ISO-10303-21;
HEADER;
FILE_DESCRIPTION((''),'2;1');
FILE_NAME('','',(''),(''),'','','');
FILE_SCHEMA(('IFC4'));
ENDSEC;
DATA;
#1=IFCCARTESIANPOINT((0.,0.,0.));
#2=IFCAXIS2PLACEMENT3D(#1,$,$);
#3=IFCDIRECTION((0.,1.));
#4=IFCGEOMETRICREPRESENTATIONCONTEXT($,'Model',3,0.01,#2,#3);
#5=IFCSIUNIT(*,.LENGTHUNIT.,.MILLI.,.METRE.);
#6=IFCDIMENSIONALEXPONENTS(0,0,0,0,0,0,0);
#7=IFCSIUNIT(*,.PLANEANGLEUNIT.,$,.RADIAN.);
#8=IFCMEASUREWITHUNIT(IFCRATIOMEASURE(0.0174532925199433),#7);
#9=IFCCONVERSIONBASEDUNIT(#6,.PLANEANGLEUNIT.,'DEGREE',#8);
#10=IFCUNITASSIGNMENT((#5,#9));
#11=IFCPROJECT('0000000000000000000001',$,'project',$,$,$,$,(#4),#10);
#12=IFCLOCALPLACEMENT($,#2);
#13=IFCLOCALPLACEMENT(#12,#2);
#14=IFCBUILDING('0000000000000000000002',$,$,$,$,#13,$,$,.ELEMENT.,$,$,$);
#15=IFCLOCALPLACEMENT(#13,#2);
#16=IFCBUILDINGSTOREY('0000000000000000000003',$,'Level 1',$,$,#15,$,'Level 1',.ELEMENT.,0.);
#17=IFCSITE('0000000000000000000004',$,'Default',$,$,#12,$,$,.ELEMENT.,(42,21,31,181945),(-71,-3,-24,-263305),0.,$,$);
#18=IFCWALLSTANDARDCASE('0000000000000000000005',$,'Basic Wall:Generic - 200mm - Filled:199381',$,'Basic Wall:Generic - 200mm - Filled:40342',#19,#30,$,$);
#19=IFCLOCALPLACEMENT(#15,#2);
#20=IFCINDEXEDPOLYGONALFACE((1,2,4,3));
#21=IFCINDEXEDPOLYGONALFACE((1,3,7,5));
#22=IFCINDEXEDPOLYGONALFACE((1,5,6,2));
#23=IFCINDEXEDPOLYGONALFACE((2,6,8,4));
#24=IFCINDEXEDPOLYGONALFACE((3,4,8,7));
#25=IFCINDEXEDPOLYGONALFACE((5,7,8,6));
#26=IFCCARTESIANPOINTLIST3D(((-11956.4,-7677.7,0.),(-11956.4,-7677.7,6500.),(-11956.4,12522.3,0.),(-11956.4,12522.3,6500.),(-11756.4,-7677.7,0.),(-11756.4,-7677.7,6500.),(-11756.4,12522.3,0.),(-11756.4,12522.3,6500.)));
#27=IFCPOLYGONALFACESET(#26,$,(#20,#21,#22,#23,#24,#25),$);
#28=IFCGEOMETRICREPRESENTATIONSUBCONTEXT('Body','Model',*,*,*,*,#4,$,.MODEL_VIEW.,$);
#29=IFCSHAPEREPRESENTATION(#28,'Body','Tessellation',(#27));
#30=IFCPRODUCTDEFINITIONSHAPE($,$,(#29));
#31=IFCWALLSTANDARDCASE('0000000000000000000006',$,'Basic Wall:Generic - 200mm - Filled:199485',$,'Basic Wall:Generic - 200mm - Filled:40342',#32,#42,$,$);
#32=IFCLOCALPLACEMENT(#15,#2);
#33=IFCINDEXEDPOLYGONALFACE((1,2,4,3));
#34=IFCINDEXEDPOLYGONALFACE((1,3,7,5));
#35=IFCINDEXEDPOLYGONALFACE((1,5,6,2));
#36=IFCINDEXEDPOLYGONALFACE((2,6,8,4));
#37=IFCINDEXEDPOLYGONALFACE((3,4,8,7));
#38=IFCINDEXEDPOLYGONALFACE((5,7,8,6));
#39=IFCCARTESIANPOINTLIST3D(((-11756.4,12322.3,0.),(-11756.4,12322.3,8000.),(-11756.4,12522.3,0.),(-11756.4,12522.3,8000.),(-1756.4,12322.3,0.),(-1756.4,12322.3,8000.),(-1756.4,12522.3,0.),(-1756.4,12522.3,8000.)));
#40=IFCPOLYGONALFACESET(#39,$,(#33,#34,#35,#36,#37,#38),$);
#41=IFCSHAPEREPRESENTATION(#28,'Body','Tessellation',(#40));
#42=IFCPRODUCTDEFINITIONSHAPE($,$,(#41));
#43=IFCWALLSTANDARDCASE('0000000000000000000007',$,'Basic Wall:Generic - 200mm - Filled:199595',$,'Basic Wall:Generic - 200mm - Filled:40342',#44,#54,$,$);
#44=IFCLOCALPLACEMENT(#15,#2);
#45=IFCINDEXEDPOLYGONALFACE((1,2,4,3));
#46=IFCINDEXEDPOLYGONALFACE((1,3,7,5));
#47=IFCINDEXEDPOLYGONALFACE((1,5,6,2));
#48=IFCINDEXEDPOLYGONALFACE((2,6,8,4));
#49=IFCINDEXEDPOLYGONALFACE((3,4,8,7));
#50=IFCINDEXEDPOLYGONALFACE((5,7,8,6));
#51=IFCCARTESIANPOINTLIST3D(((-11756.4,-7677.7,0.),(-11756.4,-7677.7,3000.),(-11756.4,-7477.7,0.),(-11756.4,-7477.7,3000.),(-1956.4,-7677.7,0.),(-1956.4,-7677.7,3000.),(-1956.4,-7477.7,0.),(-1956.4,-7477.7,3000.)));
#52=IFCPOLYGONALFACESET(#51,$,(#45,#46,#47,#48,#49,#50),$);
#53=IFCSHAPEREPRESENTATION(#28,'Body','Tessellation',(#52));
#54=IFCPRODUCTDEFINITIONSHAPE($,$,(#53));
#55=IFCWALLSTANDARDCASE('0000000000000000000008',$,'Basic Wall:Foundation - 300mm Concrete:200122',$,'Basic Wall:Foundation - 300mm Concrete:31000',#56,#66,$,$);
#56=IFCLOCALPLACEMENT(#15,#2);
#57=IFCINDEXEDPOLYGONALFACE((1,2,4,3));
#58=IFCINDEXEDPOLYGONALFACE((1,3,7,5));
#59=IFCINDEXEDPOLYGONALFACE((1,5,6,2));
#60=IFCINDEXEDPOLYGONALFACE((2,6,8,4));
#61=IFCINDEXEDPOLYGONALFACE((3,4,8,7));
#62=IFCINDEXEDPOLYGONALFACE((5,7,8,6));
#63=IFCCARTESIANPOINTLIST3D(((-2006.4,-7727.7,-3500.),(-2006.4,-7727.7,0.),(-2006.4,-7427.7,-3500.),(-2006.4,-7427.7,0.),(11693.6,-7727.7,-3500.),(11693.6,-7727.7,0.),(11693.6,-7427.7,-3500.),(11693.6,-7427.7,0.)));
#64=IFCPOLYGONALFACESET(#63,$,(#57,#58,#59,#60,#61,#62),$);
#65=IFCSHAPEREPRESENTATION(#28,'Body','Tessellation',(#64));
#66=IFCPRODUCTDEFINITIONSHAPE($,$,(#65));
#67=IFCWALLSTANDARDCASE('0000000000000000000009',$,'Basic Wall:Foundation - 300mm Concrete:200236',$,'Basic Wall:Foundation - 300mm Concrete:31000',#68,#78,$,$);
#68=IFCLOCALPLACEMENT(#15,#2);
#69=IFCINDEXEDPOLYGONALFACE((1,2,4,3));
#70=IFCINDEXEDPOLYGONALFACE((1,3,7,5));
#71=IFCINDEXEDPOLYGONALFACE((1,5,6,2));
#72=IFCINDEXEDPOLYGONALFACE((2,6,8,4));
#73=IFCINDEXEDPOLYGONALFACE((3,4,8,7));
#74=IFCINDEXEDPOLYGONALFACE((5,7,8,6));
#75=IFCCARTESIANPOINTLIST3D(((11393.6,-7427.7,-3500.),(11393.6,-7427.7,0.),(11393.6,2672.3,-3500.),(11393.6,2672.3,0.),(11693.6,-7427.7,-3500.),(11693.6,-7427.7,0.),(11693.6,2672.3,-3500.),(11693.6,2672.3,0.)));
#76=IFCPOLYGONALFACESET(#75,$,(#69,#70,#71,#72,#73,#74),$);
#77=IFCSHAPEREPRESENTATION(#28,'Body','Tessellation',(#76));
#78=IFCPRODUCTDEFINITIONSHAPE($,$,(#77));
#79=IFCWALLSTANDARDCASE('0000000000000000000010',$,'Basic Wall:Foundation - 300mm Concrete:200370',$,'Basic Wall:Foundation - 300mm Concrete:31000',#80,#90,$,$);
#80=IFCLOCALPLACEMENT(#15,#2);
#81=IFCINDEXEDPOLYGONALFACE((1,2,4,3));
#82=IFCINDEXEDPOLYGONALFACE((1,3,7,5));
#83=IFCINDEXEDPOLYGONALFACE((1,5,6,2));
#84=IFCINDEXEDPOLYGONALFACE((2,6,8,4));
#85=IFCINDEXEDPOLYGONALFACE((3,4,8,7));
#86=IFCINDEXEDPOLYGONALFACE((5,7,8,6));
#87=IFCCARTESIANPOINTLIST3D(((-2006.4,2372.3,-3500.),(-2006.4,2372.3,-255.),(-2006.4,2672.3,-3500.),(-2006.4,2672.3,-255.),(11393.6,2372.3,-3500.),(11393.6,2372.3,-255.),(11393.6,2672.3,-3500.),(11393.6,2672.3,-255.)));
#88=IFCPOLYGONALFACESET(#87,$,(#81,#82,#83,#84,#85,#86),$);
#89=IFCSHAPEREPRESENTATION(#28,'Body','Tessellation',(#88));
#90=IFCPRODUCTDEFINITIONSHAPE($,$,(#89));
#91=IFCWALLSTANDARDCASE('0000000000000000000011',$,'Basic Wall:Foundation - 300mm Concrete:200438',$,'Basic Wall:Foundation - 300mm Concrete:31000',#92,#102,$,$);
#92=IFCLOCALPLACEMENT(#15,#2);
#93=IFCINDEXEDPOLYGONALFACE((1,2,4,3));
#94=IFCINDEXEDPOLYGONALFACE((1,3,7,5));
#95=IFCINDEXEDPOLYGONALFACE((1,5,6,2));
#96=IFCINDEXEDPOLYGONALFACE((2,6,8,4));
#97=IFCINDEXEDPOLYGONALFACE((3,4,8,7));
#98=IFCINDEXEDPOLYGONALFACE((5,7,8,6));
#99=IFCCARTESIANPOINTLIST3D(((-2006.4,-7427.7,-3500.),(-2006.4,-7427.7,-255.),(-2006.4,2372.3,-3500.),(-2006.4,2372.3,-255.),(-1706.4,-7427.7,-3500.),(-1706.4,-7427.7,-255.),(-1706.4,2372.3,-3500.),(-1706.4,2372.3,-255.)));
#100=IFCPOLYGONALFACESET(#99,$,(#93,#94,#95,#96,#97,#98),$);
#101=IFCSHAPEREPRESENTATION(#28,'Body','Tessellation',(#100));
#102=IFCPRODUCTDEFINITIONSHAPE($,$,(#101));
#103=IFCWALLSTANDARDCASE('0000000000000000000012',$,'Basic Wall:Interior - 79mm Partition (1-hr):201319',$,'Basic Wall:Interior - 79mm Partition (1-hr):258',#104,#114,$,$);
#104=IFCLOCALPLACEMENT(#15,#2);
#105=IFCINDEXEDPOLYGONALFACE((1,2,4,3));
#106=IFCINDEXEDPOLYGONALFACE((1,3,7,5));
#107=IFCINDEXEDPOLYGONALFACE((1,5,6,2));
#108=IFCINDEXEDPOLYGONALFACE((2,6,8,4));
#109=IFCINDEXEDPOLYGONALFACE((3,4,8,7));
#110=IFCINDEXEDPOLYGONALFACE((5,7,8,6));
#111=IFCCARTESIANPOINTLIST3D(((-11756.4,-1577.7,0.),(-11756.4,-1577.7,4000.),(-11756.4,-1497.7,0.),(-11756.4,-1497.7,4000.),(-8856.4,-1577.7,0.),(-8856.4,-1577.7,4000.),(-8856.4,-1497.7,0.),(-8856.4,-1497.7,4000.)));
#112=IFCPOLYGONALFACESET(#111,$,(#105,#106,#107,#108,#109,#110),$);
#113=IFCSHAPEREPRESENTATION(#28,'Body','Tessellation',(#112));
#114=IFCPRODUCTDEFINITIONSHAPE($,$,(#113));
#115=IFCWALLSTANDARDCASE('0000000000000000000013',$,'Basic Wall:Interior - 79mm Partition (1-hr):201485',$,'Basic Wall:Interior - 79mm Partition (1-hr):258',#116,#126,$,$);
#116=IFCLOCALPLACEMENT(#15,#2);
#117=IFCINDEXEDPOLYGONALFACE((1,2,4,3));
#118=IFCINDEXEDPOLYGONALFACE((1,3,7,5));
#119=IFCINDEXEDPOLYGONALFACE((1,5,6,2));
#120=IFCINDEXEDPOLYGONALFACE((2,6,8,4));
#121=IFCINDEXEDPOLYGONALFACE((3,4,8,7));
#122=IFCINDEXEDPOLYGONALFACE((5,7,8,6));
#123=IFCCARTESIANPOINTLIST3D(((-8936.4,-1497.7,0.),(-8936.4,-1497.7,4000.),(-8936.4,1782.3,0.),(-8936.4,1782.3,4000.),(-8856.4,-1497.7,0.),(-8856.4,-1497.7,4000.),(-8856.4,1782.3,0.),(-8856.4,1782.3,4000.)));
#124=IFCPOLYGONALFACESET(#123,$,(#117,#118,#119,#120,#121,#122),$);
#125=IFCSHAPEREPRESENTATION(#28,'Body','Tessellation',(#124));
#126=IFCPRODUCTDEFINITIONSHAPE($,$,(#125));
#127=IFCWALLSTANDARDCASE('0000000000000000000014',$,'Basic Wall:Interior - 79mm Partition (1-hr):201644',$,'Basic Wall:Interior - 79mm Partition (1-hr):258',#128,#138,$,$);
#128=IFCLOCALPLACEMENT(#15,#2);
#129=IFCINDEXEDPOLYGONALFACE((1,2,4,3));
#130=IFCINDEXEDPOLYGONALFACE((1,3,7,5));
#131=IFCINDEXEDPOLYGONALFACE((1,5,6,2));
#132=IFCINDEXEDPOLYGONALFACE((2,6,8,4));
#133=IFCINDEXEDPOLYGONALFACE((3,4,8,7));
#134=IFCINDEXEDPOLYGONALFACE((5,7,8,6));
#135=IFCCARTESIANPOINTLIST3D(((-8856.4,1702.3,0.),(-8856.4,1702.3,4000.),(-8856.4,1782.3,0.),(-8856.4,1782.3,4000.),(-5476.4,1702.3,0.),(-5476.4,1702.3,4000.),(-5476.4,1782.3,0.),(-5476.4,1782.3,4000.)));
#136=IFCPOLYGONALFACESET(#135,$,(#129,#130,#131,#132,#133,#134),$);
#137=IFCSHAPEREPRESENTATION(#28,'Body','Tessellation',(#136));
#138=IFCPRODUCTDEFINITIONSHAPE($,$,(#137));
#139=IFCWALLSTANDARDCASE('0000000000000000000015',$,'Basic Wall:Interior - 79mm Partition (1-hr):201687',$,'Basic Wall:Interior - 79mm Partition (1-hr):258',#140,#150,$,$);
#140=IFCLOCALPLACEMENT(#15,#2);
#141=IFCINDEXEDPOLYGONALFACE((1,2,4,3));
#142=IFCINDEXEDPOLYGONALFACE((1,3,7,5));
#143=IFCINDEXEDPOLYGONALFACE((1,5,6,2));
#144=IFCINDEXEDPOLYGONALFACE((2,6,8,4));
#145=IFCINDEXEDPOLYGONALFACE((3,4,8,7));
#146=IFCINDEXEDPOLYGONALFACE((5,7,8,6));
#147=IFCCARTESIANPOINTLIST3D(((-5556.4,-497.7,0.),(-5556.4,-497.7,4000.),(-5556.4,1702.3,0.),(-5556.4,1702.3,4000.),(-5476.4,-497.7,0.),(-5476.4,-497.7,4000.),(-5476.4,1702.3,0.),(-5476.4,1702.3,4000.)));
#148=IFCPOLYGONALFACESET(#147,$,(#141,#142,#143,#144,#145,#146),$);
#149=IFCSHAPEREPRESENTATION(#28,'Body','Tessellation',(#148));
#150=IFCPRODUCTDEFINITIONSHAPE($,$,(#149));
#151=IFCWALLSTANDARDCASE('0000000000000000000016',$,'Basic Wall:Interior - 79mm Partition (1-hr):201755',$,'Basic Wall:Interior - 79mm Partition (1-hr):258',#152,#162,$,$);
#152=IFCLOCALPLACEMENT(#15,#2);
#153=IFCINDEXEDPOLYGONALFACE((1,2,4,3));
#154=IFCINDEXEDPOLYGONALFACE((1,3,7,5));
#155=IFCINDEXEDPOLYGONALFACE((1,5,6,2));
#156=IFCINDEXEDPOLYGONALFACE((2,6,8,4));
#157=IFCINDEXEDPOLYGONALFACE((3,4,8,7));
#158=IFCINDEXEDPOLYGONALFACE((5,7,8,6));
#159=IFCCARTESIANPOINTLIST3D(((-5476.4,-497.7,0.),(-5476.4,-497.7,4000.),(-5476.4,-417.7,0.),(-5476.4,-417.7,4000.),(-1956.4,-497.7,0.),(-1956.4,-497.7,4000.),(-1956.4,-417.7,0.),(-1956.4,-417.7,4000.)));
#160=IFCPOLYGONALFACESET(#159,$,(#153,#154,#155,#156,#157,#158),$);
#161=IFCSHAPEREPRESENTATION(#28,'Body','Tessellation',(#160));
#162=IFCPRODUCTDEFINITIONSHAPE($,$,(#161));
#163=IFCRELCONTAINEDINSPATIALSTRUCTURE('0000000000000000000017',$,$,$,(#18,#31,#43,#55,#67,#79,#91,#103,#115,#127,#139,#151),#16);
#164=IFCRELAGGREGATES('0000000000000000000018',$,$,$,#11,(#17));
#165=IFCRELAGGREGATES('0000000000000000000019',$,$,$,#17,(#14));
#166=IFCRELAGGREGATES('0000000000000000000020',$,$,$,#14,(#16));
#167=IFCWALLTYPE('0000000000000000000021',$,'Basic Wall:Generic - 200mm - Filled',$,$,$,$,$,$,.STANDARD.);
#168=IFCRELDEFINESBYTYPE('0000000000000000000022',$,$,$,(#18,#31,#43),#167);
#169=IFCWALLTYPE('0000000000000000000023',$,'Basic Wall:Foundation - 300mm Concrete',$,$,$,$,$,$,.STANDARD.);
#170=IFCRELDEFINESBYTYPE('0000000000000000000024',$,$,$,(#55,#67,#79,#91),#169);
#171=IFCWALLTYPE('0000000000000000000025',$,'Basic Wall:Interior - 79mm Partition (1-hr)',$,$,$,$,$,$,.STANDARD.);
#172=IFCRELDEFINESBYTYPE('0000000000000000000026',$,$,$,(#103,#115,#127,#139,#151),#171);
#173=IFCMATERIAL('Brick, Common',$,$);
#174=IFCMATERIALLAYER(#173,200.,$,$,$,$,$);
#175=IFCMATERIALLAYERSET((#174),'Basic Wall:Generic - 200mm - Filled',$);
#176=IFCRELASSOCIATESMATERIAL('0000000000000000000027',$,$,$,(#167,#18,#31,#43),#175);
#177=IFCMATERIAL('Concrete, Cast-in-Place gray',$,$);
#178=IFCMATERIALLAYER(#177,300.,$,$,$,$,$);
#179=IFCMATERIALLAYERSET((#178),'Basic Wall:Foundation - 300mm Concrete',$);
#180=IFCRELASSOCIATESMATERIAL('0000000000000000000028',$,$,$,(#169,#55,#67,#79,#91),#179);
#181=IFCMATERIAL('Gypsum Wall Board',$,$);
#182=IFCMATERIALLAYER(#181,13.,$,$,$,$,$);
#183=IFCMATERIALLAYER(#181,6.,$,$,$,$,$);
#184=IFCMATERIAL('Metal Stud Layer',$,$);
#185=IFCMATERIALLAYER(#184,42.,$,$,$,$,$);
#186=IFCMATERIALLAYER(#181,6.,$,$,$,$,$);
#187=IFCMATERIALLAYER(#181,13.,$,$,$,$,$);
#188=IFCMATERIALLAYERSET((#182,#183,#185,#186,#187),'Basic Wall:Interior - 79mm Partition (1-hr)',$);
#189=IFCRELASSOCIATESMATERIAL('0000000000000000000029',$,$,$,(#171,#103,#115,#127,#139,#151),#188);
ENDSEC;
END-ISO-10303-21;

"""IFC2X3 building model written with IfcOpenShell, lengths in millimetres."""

from ifc_helpers import new_model, entity, si_unit, converted_unit, direction, frame, frame_2d, origin, place, context, subcontext, project, spatial, polyline, rectangle, extrude, clip, bounded_halfspace, material, layer, layer_set, layer_usage, type_object, element, save


model = new_model("IFC2X3")

# Units and contexts
model_context = context("Model", 3, precision=0.01, world=origin(), true_north=direction((0.0, 1.0)))
body_context = subcontext(model_context, "Body", "Model", "MODEL_VIEW")
ifc_project = project(units=[si_unit("LENGTHUNIT", "METRE", prefix="MILLI"), converted_unit("PLANEANGLEUNIT", "DEGREE", entity("IfcRatioMeasure", 0.0174532925199433), si_unit("PLANEANGLEUNIT", "RADIAN"), dimensions=[0, 0, 0, 0, 0, 0, 0])], contexts=[model_context])

# Site, building, storey
site_placement = place(None, origin())
site = spatial("IfcSite", under=ifc_project, at=site_placement, Name="Default", CompositionType="ELEMENT", RefLatitude=(42, 21, 31, 181945), RefLongitude=(-71, -3, -24, -263305), RefElevation=0.0)
building_placement = place(site_placement, origin())
building = spatial("IfcBuilding", under=site, at=building_placement, CompositionType="ELEMENT")
storey_placement = place(building_placement, origin())
storey = spatial("IfcBuildingStorey", under=building, at=storey_placement, Name="Level 1", LongName="Level 1", CompositionType="ELEMENT", Elevation=0.0)

# Walls
ifc_material_1 = material(Name="Brick, Common")
ifc_layer_1 = layer(ifc_material_1, 200.0)
ifc_layer_set_1 = layer_set([ifc_layer_1], Name="Basic Wall:Generic - 200mm - Filled")
ifc_layer_usage_1 = layer_usage(ifc_layer_set_1, "AXIS2", "NEGATIVE", 100.0)
wall_type_1 = type_object("IfcWallType", Name="Basic Wall:Generic - 200mm - Filled", PredefinedType="STANDARD", material=ifc_layer_set_1)
wall_1_placement = place(storey_placement, frame((-11856.4, -7677.7, 0.0), z_axis=(0.0, 0.0, 1.0), x_axis=(0.0, 1.0, 0.0)))
element("IfcWallStandardCase", 1, at=wall_1_placement, inside=storey, type_object=wall_type_1, material=ifc_layer_usage_1, Name="Basic Wall:Generic - 200mm - Filled:199381", ObjectType="Basic Wall:Generic - 200mm - Filled:40342", context=body_context, shape_type="SweptSolid", body=[
    extrude(rectangle(XDim=20200.0, YDim=200.0, at=frame_2d((10100.0, 0.0), x_axis=(-1.0, 0.0))), origin(), (0.0, 0.0, 1.0), 6500.0),
])
ifc_layer_usage_2 = layer_usage(ifc_layer_set_1, "AXIS2", "NEGATIVE", 100.0)
wall_2_placement = place(storey_placement, frame((-11756.4, 12422.3, 0.0)))
element("IfcWallStandardCase", 2, at=wall_2_placement, inside=storey, type_object=wall_type_1, material=ifc_layer_usage_2, Name="Basic Wall:Generic - 200mm - Filled:199485", ObjectType="Basic Wall:Generic - 200mm - Filled:40342", context=body_context, shape_type="SweptSolid", body=[
    extrude(rectangle(XDim=10000.0, YDim=200.0, at=frame_2d((5000.0, 0.0), x_axis=(-1.0, 0.0))), origin(), (0.0, 0.0, 1.0), 8000.0),
])

# Walls
ifc_layer_usage_3 = layer_usage(ifc_layer_set_1, "AXIS2", "NEGATIVE", 100.0)
wall_3_placement = place(storey_placement, frame((-1956.4, -7577.7, 0.0), z_axis=(0.0, 0.0, 1.0), x_axis=(-1.0, 0.0, 0.0)))
element("IfcWallStandardCase", 3, at=wall_3_placement, inside=storey, type_object=wall_type_1, material=ifc_layer_usage_3, Name="Basic Wall:Generic - 200mm - Filled:199595", ObjectType="Basic Wall:Generic - 200mm - Filled:40342", context=body_context, shape_type="SweptSolid", body=[
    extrude(rectangle(XDim=9800.0, YDim=200.0, at=frame_2d((4900.0, 0.0), x_axis=(-1.0, 0.0))), origin(), (0.0, 0.0, 1.0), 3000.0),
])
ifc_material_2 = material(Name="Concrete, Cast-in-Place gray")
ifc_layer_2 = layer(ifc_material_2, 300.0)
ifc_layer_set_2 = layer_set([ifc_layer_2], Name="Basic Wall:Foundation - 300mm Concrete")
ifc_layer_usage_4 = layer_usage(ifc_layer_set_2, "AXIS2", "NEGATIVE", 150.0)
wall_type_2 = type_object("IfcWallType", Name="Basic Wall:Foundation - 300mm Concrete", PredefinedType="STANDARD", material=ifc_layer_set_2)
wall_4_placement = place(storey_placement, frame((-2006.4, -7577.7, -3500.0)))
element("IfcWallStandardCase", 4, at=wall_4_placement, inside=storey, type_object=wall_type_2, material=ifc_layer_usage_4, Name="Basic Wall:Foundation - 300mm Concrete:200122", ObjectType="Basic Wall:Foundation - 300mm Concrete:31000", context=body_context, shape_type="SweptSolid", body=[
    extrude(rectangle(XDim=13700.0, YDim=300.0, at=frame_2d((6850.0, 0.0), x_axis=(-1.0, 0.0))), origin(), (0.0, 0.0, 1.0), 3500.0),
])
ifc_layer_usage_5 = layer_usage(ifc_layer_set_2, "AXIS2", "NEGATIVE", 150.0)
wall_5_placement = place(storey_placement, frame((11543.6, -7427.7, -3500.0), z_axis=(0.0, 0.0, 1.0), x_axis=(0.0, 1.0, 0.0)))
element("IfcWallStandardCase", 5, at=wall_5_placement, inside=storey, type_object=wall_type_2, material=ifc_layer_usage_5, Name="Basic Wall:Foundation - 300mm Concrete:200236", ObjectType="Basic Wall:Foundation - 300mm Concrete:31000", context=body_context, shape_type="SweptSolid", body=[
    extrude(rectangle(XDim=10100.0, YDim=300.0, at=frame_2d((5050.0, 0.0), x_axis=(-1.0, 0.0))), origin(), (0.0, 0.0, 1.0), 3500.0),
])
ifc_layer_usage_6 = layer_usage(ifc_layer_set_2, "AXIS2", "NEGATIVE", 150.0)
wall_6_placement = place(storey_placement, frame((11393.6, 2522.3, -3500.0), z_axis=(0.0, 0.0, 1.0), x_axis=(-1.0, 0.0, 0.0)))
element("IfcWallStandardCase", 6, at=wall_6_placement, inside=storey, type_object=wall_type_2, material=ifc_layer_usage_6, Name="Basic Wall:Foundation - 300mm Concrete:200370", ObjectType="Basic Wall:Foundation - 300mm Concrete:31000", context=body_context, shape_type="Clipping", body=[
    clip(extrude(rectangle(XDim=13400.0, YDim=300.0, at=frame_2d((6700.0, 0.0), x_axis=(-1.0, 0.0))), origin(), (0.0, 0.0, 1.0), 3245.0), bounded_halfspace(frame((13350.0, -150.0, 3245.0), z_axis=(0.0, 0.0, -1.0), x_axis=(0.0, 1.0, 0.0)), True, frame((13350.0, -150.0, 3245.0)), polyline([(0.0, 0.0), (50.0, 0.0), (50.0, 300.0), (0.0, 300.0), (0.0, 0.0)]))),
])
ifc_layer_usage_7 = layer_usage(ifc_layer_set_2, "AXIS2", "NEGATIVE", 150.0)
wall_7_placement = place(storey_placement, frame((-1856.4, 2372.3, -3500.0), z_axis=(0.0, 0.0, 1.0), x_axis=(0.0, -1.0, 0.0)))
element("IfcWallStandardCase", 7, at=wall_7_placement, inside=storey, type_object=wall_type_2, material=ifc_layer_usage_7, Name="Basic Wall:Foundation - 300mm Concrete:200438", ObjectType="Basic Wall:Foundation - 300mm Concrete:31000", context=body_context, shape_type="Clipping", body=[
    clip(extrude(rectangle(XDim=9800.0, YDim=300.0, at=frame_2d((4900.0, 0.0), x_axis=(-1.0, 0.0))), origin(), (0.0, 0.0, 1.0), 3245.0), bounded_halfspace(frame((0.0, -150.0, 3245.0), z_axis=(0.0, 0.0, -1.0), x_axis=(1.0, 0.0, 0.0)), True, frame((0.0, -150.0, 3245.0)), polyline([(0.0, 0.0), (2790.0, 0.0), (2790.0, 50.0), (0.0, 50.0), (0.0, 0.0)]))),
])
ifc_material_3 = material(Name="Gypsum Wall Board")
ifc_layer_3 = layer(ifc_material_3, 13.0)
ifc_layer_4 = layer(ifc_material_3, 6.0)
ifc_material_4 = material(Name="Metal Stud Layer")
ifc_layer_5 = layer(ifc_material_4, 42.0)
ifc_layer_6 = layer(ifc_material_3, 6.0)
ifc_layer_7 = layer(ifc_material_3, 13.0)
ifc_layer_set_3 = layer_set([ifc_layer_3, ifc_layer_4, ifc_layer_5, ifc_layer_6, ifc_layer_7], Name="Basic Wall:Interior - 79mm Partition (1-hr)")
ifc_layer_usage_8 = layer_usage(ifc_layer_set_3, "AXIS2", "NEGATIVE", 40.0)
wall_type_3 = type_object("IfcWallType", Name="Basic Wall:Interior - 79mm Partition (1-hr)", PredefinedType="STANDARD", material=ifc_layer_set_3)
wall_8_placement = place(storey_placement, frame((-11756.4, -1537.7, 0.0)))
element("IfcWallStandardCase", 8, at=wall_8_placement, inside=storey, type_object=wall_type_3, material=ifc_layer_usage_8, Name="Basic Wall:Interior - 79mm Partition (1-hr):201319", ObjectType="Basic Wall:Interior - 79mm Partition (1-hr):258", context=body_context, shape_type="SweptSolid", body=[
    extrude(rectangle(XDim=2900.0, YDim=80.0, at=frame_2d((1450.0, 0.0), x_axis=(-1.0, 0.0))), origin(), (0.0, 0.0, 1.0), 4000.0),
])
ifc_layer_usage_9 = layer_usage(ifc_layer_set_3, "AXIS2", "NEGATIVE", 40.0)
wall_9_placement = place(storey_placement, frame((-8896.4, -1497.7, 0.0), z_axis=(0.0, 0.0, 1.0), x_axis=(0.0, 1.0, 0.0)))
element("IfcWallStandardCase", 9, at=wall_9_placement, inside=storey, type_object=wall_type_3, material=ifc_layer_usage_9, Name="Basic Wall:Interior - 79mm Partition (1-hr):201485", ObjectType="Basic Wall:Interior - 79mm Partition (1-hr):258", context=body_context, shape_type="SweptSolid", body=[
    extrude(rectangle(XDim=3280.0, YDim=80.0, at=frame_2d((1640.0, 0.0), x_axis=(-1.0, 0.0))), origin(), (0.0, 0.0, 1.0), 4000.0),
])
ifc_layer_usage_10 = layer_usage(ifc_layer_set_3, "AXIS2", "NEGATIVE", 40.0)
wall_10_placement = place(storey_placement, frame((-8856.4, 1742.3, 0.0)))
element("IfcWallStandardCase", 10, at=wall_10_placement, inside=storey, type_object=wall_type_3, material=ifc_layer_usage_10, Name="Basic Wall:Interior - 79mm Partition (1-hr):201644", ObjectType="Basic Wall:Interior - 79mm Partition (1-hr):258", context=body_context, shape_type="SweptSolid", body=[
    extrude(rectangle(XDim=3380.0, YDim=80.0, at=frame_2d((1690.0, 0.0), x_axis=(-1.0, 0.0))), origin(), (0.0, 0.0, 1.0), 4000.0),
])
ifc_layer_usage_11 = layer_usage(ifc_layer_set_3, "AXIS2", "NEGATIVE", 40.0)
wall_11_placement = place(storey_placement, frame((-5516.4, 1702.3, 0.0), z_axis=(0.0, 0.0, 1.0), x_axis=(0.0, -1.0, 0.0)))
element("IfcWallStandardCase", 11, at=wall_11_placement, inside=storey, type_object=wall_type_3, material=ifc_layer_usage_11, Name="Basic Wall:Interior - 79mm Partition (1-hr):201687", ObjectType="Basic Wall:Interior - 79mm Partition (1-hr):258", context=body_context, shape_type="SweptSolid", body=[
    extrude(rectangle(XDim=2200.0, YDim=80.0, at=frame_2d((1100.0, 0.0), x_axis=(-1.0, 0.0))), origin(), (0.0, 0.0, 1.0), 4000.0),
])
ifc_layer_usage_12 = layer_usage(ifc_layer_set_3, "AXIS2", "NEGATIVE", 40.0)
wall_12_placement = place(storey_placement, frame((-5476.4, -457.7, 0.0)))
element("IfcWallStandardCase", 12, at=wall_12_placement, inside=storey, type_object=wall_type_3, material=ifc_layer_usage_12, Name="Basic Wall:Interior - 79mm Partition (1-hr):201755", ObjectType="Basic Wall:Interior - 79mm Partition (1-hr):258", context=body_context, shape_type="SweptSolid", body=[
    extrude(rectangle(XDim=3520.0, YDim=80.0, at=frame_2d((1760.0, 0.0), x_axis=(-1.0, 0.0))), origin(), (0.0, 0.0, 1.0), 4000.0),
])

save(model, "model.ifc")
